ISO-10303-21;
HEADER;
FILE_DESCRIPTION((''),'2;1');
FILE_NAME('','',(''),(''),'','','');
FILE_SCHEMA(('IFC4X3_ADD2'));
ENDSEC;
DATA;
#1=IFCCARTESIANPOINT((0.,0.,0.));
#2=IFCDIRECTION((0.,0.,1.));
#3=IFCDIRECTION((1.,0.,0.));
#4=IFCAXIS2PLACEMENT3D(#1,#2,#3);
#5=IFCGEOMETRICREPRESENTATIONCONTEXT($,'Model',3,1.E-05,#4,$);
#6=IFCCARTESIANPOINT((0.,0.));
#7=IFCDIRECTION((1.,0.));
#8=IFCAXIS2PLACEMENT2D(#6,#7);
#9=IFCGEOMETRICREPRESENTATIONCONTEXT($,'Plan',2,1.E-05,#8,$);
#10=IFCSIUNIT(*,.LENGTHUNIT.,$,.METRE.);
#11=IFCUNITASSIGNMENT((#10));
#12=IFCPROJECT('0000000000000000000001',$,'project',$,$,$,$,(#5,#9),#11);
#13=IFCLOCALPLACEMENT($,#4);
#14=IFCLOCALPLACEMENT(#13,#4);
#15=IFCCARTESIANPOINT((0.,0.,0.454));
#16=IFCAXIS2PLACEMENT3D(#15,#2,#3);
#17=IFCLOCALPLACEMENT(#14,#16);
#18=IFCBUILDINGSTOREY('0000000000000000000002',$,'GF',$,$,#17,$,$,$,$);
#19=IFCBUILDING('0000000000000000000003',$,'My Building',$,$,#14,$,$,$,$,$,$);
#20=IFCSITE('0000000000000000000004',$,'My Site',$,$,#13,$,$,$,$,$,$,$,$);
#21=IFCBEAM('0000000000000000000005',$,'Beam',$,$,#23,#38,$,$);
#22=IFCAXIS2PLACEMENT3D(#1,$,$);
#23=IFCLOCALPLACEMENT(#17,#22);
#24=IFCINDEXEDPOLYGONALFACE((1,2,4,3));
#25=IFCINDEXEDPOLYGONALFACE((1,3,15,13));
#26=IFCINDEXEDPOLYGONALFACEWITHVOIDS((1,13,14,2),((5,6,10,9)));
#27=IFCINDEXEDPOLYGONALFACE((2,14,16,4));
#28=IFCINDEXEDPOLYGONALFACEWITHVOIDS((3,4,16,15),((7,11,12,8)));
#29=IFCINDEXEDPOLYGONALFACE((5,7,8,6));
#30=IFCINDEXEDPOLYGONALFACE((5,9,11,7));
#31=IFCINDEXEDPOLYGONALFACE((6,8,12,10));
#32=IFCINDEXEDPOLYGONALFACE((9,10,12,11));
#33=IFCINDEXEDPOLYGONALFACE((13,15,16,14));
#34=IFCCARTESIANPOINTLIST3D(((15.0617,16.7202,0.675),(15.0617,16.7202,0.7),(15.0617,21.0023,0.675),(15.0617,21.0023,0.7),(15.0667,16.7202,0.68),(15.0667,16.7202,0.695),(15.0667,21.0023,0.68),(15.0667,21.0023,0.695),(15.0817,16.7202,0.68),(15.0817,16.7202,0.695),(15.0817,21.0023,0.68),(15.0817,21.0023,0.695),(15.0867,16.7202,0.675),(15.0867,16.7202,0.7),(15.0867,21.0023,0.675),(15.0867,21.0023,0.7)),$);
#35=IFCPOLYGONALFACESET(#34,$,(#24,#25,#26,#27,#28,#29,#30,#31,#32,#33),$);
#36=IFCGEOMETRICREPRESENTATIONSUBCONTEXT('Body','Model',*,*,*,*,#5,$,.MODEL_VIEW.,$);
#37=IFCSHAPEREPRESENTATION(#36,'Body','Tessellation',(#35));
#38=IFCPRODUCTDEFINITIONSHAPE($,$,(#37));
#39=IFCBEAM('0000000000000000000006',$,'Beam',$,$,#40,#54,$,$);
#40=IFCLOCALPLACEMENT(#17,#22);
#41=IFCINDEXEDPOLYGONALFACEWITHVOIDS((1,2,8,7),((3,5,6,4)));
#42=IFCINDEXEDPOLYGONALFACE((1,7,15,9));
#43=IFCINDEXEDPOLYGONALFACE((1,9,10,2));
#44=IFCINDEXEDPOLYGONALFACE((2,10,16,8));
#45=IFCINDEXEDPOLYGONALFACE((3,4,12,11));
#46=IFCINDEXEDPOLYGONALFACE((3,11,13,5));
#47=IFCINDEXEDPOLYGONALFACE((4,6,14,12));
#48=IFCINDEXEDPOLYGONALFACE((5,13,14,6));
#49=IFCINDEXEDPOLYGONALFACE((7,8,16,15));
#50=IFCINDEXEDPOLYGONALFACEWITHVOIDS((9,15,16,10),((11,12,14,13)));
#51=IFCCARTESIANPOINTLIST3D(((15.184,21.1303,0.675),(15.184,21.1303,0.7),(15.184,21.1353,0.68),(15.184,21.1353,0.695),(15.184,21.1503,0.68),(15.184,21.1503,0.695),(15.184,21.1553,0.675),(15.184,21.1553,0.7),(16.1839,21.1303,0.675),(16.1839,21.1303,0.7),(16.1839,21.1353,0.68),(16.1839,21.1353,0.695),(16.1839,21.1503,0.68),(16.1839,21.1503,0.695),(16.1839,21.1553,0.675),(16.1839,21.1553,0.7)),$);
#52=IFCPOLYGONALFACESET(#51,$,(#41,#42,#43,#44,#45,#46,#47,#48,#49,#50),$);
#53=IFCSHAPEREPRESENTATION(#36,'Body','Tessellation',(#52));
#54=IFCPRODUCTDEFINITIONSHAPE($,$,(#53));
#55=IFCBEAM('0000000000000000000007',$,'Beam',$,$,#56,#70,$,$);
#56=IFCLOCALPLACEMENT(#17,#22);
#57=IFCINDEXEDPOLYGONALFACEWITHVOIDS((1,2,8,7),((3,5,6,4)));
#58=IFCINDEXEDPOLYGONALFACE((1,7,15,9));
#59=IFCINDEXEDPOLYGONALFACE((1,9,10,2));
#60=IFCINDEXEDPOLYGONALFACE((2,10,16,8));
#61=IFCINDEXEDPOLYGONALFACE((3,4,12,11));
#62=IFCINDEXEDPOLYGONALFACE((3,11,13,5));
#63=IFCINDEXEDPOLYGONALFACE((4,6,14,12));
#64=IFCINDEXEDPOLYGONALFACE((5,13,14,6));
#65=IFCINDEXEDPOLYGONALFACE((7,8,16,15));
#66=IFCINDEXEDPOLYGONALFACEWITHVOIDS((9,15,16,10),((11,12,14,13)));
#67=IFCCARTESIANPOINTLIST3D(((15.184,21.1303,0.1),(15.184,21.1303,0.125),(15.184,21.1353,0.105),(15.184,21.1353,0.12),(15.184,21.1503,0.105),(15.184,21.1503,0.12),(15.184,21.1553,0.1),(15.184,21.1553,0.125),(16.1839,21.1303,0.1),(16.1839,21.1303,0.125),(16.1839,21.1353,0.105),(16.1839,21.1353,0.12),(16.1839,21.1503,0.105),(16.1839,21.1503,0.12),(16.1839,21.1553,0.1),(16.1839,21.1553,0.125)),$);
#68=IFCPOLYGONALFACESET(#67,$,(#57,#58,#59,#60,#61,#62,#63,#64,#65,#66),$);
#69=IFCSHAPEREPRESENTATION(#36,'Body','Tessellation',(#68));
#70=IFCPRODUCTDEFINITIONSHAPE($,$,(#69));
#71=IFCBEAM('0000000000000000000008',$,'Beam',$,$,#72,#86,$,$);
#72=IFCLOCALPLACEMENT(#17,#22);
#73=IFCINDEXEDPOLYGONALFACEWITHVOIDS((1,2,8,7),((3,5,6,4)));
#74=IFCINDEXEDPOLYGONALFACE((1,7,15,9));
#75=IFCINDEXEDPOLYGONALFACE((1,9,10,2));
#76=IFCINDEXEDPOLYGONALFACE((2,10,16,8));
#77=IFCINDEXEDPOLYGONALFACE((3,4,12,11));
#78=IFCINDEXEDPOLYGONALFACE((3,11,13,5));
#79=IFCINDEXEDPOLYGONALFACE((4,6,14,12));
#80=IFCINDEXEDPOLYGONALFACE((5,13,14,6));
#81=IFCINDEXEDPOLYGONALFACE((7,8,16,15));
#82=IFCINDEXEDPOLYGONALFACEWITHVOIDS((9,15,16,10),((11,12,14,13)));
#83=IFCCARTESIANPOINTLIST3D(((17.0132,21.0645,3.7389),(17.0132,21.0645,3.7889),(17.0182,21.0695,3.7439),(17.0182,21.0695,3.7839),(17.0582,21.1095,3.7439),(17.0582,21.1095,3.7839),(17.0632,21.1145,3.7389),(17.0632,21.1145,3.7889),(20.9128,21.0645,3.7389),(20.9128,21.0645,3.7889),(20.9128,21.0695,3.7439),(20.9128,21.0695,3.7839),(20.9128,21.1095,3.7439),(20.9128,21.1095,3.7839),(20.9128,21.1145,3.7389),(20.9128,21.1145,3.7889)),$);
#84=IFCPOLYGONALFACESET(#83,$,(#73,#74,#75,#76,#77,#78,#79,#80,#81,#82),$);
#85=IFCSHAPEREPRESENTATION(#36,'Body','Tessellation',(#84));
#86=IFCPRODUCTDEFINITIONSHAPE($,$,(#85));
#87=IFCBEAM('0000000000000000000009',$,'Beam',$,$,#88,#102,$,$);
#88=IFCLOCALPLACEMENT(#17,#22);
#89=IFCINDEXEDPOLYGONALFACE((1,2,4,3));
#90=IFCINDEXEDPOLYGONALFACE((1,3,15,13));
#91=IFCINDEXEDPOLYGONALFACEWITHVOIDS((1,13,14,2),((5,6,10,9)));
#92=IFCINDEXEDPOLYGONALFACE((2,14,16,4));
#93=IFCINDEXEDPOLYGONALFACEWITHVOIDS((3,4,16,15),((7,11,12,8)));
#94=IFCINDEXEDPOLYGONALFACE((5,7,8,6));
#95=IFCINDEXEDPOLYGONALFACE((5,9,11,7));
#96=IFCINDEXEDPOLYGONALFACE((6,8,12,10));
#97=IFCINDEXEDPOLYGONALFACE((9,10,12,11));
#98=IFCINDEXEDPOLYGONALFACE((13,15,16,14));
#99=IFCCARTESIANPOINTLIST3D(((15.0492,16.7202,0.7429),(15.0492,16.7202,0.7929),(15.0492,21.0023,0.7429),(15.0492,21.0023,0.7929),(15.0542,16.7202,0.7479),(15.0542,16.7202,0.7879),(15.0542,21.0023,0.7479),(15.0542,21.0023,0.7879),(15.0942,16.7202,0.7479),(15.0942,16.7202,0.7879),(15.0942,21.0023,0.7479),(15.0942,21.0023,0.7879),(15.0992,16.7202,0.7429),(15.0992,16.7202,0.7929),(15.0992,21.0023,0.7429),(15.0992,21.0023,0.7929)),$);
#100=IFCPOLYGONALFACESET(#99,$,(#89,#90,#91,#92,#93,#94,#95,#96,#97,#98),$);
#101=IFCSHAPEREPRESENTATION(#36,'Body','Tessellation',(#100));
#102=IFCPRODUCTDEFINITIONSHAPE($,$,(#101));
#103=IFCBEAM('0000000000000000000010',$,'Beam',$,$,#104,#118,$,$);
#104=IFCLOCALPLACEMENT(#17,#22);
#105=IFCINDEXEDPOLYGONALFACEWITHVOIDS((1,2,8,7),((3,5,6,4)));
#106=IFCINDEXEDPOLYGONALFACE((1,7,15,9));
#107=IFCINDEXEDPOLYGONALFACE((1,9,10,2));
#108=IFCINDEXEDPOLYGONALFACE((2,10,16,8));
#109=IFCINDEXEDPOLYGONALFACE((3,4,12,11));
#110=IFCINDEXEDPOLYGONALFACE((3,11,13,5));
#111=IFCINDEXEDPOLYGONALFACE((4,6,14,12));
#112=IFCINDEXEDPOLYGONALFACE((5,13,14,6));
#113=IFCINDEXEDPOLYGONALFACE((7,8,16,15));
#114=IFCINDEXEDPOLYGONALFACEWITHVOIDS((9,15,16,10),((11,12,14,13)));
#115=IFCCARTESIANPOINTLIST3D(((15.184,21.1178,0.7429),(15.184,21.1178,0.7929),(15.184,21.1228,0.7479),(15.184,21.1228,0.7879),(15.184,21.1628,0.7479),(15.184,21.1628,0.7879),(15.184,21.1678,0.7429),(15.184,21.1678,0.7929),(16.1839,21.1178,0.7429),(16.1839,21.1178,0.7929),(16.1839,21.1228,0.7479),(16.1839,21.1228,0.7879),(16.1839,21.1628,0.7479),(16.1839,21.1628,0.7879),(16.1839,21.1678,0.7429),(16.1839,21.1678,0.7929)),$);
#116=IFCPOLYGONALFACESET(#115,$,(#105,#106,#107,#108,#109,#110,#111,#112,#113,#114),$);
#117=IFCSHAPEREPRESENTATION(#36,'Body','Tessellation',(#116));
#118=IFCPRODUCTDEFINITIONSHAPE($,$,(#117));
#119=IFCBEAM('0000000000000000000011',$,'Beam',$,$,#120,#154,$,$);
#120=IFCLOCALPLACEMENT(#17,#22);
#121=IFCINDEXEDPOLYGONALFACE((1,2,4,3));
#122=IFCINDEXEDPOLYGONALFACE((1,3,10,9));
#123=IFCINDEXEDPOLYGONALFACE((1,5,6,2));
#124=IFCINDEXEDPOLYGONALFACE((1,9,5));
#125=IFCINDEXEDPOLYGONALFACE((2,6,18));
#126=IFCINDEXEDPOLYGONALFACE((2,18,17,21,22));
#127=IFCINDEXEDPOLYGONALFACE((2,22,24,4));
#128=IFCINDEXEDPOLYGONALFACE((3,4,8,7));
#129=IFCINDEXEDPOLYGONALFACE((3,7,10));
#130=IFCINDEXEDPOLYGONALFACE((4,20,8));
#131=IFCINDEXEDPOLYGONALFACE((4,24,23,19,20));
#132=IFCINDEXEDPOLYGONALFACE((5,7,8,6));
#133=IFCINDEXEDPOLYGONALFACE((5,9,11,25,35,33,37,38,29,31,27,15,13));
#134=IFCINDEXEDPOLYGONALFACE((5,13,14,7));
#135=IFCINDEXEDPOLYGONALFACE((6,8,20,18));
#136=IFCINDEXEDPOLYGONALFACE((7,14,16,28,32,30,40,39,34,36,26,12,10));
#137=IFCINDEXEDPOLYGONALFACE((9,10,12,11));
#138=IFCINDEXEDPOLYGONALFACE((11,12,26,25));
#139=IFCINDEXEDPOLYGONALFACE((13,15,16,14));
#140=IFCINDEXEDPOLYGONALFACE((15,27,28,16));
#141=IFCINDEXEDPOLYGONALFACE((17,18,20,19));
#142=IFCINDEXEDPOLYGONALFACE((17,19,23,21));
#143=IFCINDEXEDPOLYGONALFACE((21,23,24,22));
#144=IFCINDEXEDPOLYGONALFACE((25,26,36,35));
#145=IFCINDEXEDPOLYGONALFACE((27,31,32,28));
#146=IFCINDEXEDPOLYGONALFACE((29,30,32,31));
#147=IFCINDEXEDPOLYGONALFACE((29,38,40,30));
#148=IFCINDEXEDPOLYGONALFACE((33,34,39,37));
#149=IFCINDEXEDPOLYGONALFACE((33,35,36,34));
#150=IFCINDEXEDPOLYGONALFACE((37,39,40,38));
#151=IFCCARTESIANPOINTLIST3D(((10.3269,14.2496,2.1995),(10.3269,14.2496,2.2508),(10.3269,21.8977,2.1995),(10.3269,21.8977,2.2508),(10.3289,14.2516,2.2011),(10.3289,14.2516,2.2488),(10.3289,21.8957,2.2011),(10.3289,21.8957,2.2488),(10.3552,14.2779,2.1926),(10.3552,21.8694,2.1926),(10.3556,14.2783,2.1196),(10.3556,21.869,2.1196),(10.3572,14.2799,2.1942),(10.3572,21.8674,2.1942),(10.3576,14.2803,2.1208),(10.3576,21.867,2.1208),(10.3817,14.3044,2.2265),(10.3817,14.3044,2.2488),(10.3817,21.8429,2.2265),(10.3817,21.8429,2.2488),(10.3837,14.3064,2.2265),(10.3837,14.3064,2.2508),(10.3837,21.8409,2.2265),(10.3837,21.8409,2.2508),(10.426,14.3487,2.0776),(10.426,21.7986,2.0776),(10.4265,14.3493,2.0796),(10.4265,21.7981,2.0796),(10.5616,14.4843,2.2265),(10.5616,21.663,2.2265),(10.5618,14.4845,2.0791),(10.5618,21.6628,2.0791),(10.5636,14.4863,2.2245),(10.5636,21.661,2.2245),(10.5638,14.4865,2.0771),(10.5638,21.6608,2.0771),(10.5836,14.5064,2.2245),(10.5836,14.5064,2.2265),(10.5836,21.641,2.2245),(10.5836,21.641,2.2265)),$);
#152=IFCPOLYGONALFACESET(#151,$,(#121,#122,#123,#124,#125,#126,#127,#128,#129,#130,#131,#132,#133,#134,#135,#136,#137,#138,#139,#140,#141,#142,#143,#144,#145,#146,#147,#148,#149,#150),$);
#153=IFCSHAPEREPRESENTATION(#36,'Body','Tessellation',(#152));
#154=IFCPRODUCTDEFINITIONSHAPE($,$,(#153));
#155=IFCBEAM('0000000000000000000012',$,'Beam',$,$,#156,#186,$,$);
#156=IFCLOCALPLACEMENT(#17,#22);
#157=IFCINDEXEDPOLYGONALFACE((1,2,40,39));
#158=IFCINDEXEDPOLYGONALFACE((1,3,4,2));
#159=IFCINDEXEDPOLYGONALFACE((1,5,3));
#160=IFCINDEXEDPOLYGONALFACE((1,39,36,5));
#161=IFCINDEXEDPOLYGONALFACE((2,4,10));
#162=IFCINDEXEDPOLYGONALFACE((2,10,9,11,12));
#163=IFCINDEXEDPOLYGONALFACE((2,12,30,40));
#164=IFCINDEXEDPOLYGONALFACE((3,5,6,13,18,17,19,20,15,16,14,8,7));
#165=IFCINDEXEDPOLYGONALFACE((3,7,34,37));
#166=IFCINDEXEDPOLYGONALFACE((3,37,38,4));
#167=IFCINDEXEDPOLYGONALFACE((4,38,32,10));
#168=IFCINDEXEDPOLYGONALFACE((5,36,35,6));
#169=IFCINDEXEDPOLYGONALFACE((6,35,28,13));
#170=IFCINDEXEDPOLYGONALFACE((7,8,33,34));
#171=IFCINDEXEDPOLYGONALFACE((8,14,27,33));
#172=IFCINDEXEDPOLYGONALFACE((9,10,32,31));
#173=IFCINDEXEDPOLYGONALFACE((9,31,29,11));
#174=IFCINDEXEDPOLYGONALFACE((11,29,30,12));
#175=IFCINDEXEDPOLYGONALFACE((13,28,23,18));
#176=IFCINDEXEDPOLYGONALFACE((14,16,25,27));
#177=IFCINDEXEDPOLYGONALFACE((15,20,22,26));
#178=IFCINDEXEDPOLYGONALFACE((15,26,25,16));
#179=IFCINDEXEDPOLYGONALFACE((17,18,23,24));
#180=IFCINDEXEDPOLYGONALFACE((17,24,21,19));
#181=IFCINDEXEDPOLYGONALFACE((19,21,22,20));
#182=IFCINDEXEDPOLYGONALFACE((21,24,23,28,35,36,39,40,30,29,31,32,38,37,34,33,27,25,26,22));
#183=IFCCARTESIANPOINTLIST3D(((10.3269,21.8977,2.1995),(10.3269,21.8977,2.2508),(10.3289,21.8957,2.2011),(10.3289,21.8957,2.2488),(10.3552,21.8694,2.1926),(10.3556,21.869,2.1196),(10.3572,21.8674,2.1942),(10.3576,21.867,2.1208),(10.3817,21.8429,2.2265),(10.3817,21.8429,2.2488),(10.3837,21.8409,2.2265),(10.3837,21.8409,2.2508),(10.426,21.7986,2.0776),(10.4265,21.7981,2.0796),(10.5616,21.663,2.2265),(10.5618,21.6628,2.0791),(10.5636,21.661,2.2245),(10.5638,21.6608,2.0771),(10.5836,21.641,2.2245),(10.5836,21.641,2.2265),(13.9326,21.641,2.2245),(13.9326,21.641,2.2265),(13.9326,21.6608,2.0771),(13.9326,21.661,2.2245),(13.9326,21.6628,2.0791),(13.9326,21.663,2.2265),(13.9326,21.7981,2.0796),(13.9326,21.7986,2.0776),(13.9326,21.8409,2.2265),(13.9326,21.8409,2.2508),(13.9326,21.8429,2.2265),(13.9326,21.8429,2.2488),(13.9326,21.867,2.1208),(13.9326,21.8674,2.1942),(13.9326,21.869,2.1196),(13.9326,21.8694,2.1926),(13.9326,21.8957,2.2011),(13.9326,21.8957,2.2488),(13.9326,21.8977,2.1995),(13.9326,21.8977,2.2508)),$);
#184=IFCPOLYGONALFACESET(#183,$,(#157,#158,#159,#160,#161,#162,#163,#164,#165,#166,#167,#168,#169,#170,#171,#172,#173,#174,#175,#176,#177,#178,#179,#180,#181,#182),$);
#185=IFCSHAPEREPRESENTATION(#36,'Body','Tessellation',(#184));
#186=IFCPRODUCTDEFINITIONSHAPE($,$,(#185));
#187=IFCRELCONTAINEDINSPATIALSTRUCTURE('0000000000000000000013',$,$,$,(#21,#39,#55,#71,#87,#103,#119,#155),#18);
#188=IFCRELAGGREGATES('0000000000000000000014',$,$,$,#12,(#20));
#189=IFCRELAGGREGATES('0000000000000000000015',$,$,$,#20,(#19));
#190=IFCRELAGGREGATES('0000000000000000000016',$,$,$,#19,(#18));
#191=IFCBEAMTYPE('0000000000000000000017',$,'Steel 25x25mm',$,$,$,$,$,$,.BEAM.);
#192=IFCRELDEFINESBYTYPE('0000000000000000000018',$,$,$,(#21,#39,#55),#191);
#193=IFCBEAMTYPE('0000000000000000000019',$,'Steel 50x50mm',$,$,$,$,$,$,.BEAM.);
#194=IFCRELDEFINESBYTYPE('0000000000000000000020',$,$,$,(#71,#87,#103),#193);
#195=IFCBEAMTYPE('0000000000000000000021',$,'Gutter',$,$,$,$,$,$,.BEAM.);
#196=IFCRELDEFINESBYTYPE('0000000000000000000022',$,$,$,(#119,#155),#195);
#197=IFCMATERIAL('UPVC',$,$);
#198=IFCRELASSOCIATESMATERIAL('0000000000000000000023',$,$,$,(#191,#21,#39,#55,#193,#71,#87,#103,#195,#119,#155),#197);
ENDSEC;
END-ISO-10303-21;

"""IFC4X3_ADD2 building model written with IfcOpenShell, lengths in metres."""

from ifc_helpers import new_model, si_unit, frame, origin_with_axes, origin_2d_with_axis, place, context, subcontext, project, spatial, indexed_curve, hollow_rectangle, outline, extrude, clip, halfspace, material, material_profile, profile_set, profile_usage, type_object, element, save


model = new_model("IFC4X3_ADD2")

# Units and contexts
model_context = context("Model", 3, precision=1e-05, world=origin_with_axes())
plan_context = context("Plan", 2, precision=1e-05, world=origin_2d_with_axis())
body_context = subcontext(model_context, "Body", "Model", "MODEL_VIEW")
ifc_project = project(units=[si_unit("LENGTHUNIT", "METRE")], contexts=[model_context, plan_context])

# Site, building, storey
site_placement = place(None, origin_with_axes())
site = spatial("IfcSite", under=ifc_project, at=site_placement, Name="My Site")
building_placement = place(site_placement, origin_with_axes())
building = spatial("IfcBuilding", under=site, at=building_placement, Name="My Building")
storey_placement = place(building_placement, frame((0.0, 0.0, 0.454), z_axis=(0.0, 0.0, 1.0), x_axis=(1.0, 0.0, 0.0)))
storey = spatial("IfcBuildingStorey", under=building, at=storey_placement, Name="GF")

# Shared definitions
ifc_material_1 = material(Name="UPVC")

# Beams
ifc_material_profile_1 = material_profile(ifc_material_1, hollow_rectangle(XDim=0.025, YDim=0.025, WallThickness=0.005))
ifc_profile_set_1 = profile_set([ifc_material_profile_1])
beam_type_1 = type_object("IfcBeamType", Name="Steel 25x25mm", PredefinedType="BEAM", material=ifc_profile_set_1)
ifc_profile_usage_1 = profile_usage(ifc_profile_set_1)
beam_1_placement = place(storey_placement, frame((15.0742, 21.0023, 0.6875), z_axis=(0.0, -1.0, 0.0), x_axis=(1.0, 0.0, 0.0)))
element("IfcBeam", 1, at=beam_1_placement, inside=storey, type_object=beam_type_1, material=ifc_profile_usage_1, Name="Beam", context=body_context, shape_type="SweptSolid", body=[
    extrude(hollow_rectangle(XDim=0.025, YDim=0.025, WallThickness=0.005), origin_with_axes(), (0.0, 0.0, 1.0), 4.2821),
])
ifc_profile_usage_2 = profile_usage(ifc_profile_set_1)
beam_2_placement = place(storey_placement, frame((15.184, 21.1428, 0.6875), z_axis=(1.0, 0.0, 0.0), x_axis=(0.0, 1.0, 0.0)))
element("IfcBeam", 2, at=beam_2_placement, inside=storey, type_object=beam_type_1, material=ifc_profile_usage_2, Name="Beam", context=body_context, shape_type="SweptSolid", body=[
    extrude(hollow_rectangle(XDim=0.025, YDim=0.025, WallThickness=0.005), origin_with_axes(), (0.0, 0.0, 1.0), 1.0),
])
ifc_profile_usage_3 = profile_usage(ifc_profile_set_1)
beam_3_placement = place(storey_placement, frame((15.184, 21.1428, 0.1125), z_axis=(1.0, 0.0, 0.0), x_axis=(0.0, 1.0, 0.0)))
element("IfcBeam", 3, at=beam_3_placement, inside=storey, type_object=beam_type_1, material=ifc_profile_usage_3, Name="Beam", context=body_context, shape_type="SweptSolid", body=[
    extrude(hollow_rectangle(XDim=0.025, YDim=0.025, WallThickness=0.005), origin_with_axes(), (0.0, 0.0, 1.0), 1.0),
])
ifc_material_profile_2 = material_profile(ifc_material_1, hollow_rectangle(XDim=0.05, YDim=0.05, WallThickness=0.005))
ifc_profile_set_2 = profile_set([ifc_material_profile_2])
ifc_profile_usage_4 = profile_usage(ifc_profile_set_2)
beam_type_2 = type_object("IfcBeamType", Name="Steel 50x50mm", PredefinedType="BEAM", material=ifc_profile_set_2)
beam_4_placement = place(storey_placement, frame((17.0132, 21.0895, 3.7639), z_axis=(1.0, 0.0, 0.0), x_axis=(0.0, 1.0, 0.0)))
element("IfcBeam", 4, at=beam_4_placement, inside=storey, type_object=beam_type_2, material=ifc_profile_usage_4, Name="Beam", context=body_context, shape_type="Clipping", body=[
    clip(extrude(hollow_rectangle(XDim=0.05, YDim=0.05, WallThickness=0.005), origin_with_axes(), (0.0, 0.0, 1.0), 3.8996), halfspace(frame((-0.025, -4.2179, 0.0), z_axis=(0.707107, 0.0, -0.707107), x_axis=(0.0, -1.0, 0.0)), False)),
])
ifc_profile_usage_5 = profile_usage(ifc_profile_set_2)
beam_5_placement = place(storey_placement, frame((15.0742, 21.0023, 0.7679), z_axis=(0.0, -1.0, 0.0), x_axis=(1.0, 0.0, 0.0)))
element("IfcBeam", 5, at=beam_5_placement, inside=storey, type_object=beam_type_2, material=ifc_profile_usage_5, Name="Beam", context=body_context, shape_type="SweptSolid", body=[
    extrude(hollow_rectangle(XDim=0.05, YDim=0.05, WallThickness=0.005), origin_with_axes(), (0.0, 0.0, 1.0), 4.2821),
])
ifc_profile_usage_6 = profile_usage(ifc_profile_set_2)
beam_6_placement = place(storey_placement, frame((15.184, 21.1428, 0.7679), z_axis=(1.0, 0.0, 0.0), x_axis=(0.0, 1.0, 0.0)))
element("IfcBeam", 6, at=beam_6_placement, inside=storey, type_object=beam_type_2, material=ifc_profile_usage_6, Name="Beam", context=body_context, shape_type="SweptSolid", body=[
    extrude(hollow_rectangle(XDim=0.05, YDim=0.05, WallThickness=0.005), origin_with_axes(), (0.0, 0.0, 1.0), 1.0),
])
ifc_material_profile_3 = material_profile(ifc_material_1, outline(indexed_curve([(0.0548, 0.1717), (0.002, 0.1717), (0.002, 0.124), (0.0303, 0.1171), (0.0307, 0.0436), (0.0996, 0.0025), (0.2349, 0.002), (0.2347, 0.1494), (0.2567, 0.1494), (0.2567, 0.1474), (0.2367, 0.1474), (0.2369, 0.0), (0.0991, 0.0005), (0.0287, 0.0425), (0.0283, 0.1155), (0.0, 0.1224), (0.0, 0.1737), (0.0568, 0.1737), (0.0568, 0.1494), (0.0548, 0.1494), (0.0548, 0.1717)])))
ifc_profile_set_3 = profile_set([ifc_material_profile_3])
ifc_profile_usage_7 = profile_usage(ifc_profile_set_3)
beam_type_3 = type_object("IfcBeamType", Name="Gutter", PredefinedType="BEAM", material=ifc_profile_set_3)
beam_7_placement = place(storey_placement, frame((10.3269, 21.8977, 2.0771), z_axis=(0.0, -1.0, 0.0), x_axis=(1.0, 0.0, 0.0)))
element("IfcBeam", 7, at=beam_7_placement, inside=storey, type_object=beam_type_3, material=ifc_profile_usage_7, Name="Beam", context=body_context, shape_type="Clipping", body=[
    clip(clip(extrude(outline(indexed_curve([(0.0548, 0.1717), (0.002, 0.1717), (0.002, 0.124), (0.0303, 0.1171), (0.0307, 0.0436), (0.0996, 0.0025), (0.2349, 0.002), (0.2347, 0.1494), (0.2567, 0.1494), (0.2567, 0.1474), (0.2367, 0.1474), (0.2369, 0.0), (0.0991, 0.0005), (0.0287, 0.0425), (0.0283, 0.1155), (0.0, 0.1224), (0.0, 0.1737), (0.0568, 0.1737), (0.0568, 0.1494), (0.0548, 0.1494), (0.0548, 0.1717)])), origin_with_axes(), (0.0, 0.0, 1.0), 7.6481), halfspace(frame((0.0, -2.3765, 0.0), z_axis=(0.707106, 0.0, -0.707107), x_axis=(0.0, -1.0, 0.0)), False)), halfspace(frame((0.0, -2.3765, 7.6481), z_axis=(0.707107, 0.0, 0.707106), x_axis=(0.0, -1.0, 0.0)), False)),
])
ifc_profile_usage_8 = profile_usage(ifc_profile_set_3)
beam_8_placement = place(storey_placement, frame((13.9326, 21.8977, 2.0771), z_axis=(-1.0, 0.000001, 0.0), x_axis=(-0.000001, -1.0, 0.0)))
element("IfcBeam", 8, at=beam_8_placement, inside=storey, type_object=beam_type_3, material=ifc_profile_usage_8, Name="Beam", context=body_context, shape_type="Clipping", body=[
    clip(extrude(outline(indexed_curve([(0.0548, 0.1717), (0.002, 0.1717), (0.002, 0.124), (0.0303, 0.1171), (0.0307, 0.0436), (0.0996, 0.0025), (0.2349, 0.002), (0.2347, 0.1494), (0.2567, 0.1494), (0.2567, 0.1474), (0.2367, 0.1474), (0.2369, 0.0), (0.0991, 0.0005), (0.0287, 0.0425), (0.0283, 0.1155), (0.0, 0.1224), (0.0, 0.1737), (0.0568, 0.1737), (0.0568, 0.1494), (0.0548, 0.1494), (0.0548, 0.1717)])), origin_with_axes(), (0.0, 0.0, 1.0), 3.6057), halfspace(frame((0.0, -2.3765, 3.6057), z_axis=(0.707107, 0.0, 0.707106), x_axis=(0.0, -1.0, 0.0)), False)),
])

save(model, "model.ifc")
